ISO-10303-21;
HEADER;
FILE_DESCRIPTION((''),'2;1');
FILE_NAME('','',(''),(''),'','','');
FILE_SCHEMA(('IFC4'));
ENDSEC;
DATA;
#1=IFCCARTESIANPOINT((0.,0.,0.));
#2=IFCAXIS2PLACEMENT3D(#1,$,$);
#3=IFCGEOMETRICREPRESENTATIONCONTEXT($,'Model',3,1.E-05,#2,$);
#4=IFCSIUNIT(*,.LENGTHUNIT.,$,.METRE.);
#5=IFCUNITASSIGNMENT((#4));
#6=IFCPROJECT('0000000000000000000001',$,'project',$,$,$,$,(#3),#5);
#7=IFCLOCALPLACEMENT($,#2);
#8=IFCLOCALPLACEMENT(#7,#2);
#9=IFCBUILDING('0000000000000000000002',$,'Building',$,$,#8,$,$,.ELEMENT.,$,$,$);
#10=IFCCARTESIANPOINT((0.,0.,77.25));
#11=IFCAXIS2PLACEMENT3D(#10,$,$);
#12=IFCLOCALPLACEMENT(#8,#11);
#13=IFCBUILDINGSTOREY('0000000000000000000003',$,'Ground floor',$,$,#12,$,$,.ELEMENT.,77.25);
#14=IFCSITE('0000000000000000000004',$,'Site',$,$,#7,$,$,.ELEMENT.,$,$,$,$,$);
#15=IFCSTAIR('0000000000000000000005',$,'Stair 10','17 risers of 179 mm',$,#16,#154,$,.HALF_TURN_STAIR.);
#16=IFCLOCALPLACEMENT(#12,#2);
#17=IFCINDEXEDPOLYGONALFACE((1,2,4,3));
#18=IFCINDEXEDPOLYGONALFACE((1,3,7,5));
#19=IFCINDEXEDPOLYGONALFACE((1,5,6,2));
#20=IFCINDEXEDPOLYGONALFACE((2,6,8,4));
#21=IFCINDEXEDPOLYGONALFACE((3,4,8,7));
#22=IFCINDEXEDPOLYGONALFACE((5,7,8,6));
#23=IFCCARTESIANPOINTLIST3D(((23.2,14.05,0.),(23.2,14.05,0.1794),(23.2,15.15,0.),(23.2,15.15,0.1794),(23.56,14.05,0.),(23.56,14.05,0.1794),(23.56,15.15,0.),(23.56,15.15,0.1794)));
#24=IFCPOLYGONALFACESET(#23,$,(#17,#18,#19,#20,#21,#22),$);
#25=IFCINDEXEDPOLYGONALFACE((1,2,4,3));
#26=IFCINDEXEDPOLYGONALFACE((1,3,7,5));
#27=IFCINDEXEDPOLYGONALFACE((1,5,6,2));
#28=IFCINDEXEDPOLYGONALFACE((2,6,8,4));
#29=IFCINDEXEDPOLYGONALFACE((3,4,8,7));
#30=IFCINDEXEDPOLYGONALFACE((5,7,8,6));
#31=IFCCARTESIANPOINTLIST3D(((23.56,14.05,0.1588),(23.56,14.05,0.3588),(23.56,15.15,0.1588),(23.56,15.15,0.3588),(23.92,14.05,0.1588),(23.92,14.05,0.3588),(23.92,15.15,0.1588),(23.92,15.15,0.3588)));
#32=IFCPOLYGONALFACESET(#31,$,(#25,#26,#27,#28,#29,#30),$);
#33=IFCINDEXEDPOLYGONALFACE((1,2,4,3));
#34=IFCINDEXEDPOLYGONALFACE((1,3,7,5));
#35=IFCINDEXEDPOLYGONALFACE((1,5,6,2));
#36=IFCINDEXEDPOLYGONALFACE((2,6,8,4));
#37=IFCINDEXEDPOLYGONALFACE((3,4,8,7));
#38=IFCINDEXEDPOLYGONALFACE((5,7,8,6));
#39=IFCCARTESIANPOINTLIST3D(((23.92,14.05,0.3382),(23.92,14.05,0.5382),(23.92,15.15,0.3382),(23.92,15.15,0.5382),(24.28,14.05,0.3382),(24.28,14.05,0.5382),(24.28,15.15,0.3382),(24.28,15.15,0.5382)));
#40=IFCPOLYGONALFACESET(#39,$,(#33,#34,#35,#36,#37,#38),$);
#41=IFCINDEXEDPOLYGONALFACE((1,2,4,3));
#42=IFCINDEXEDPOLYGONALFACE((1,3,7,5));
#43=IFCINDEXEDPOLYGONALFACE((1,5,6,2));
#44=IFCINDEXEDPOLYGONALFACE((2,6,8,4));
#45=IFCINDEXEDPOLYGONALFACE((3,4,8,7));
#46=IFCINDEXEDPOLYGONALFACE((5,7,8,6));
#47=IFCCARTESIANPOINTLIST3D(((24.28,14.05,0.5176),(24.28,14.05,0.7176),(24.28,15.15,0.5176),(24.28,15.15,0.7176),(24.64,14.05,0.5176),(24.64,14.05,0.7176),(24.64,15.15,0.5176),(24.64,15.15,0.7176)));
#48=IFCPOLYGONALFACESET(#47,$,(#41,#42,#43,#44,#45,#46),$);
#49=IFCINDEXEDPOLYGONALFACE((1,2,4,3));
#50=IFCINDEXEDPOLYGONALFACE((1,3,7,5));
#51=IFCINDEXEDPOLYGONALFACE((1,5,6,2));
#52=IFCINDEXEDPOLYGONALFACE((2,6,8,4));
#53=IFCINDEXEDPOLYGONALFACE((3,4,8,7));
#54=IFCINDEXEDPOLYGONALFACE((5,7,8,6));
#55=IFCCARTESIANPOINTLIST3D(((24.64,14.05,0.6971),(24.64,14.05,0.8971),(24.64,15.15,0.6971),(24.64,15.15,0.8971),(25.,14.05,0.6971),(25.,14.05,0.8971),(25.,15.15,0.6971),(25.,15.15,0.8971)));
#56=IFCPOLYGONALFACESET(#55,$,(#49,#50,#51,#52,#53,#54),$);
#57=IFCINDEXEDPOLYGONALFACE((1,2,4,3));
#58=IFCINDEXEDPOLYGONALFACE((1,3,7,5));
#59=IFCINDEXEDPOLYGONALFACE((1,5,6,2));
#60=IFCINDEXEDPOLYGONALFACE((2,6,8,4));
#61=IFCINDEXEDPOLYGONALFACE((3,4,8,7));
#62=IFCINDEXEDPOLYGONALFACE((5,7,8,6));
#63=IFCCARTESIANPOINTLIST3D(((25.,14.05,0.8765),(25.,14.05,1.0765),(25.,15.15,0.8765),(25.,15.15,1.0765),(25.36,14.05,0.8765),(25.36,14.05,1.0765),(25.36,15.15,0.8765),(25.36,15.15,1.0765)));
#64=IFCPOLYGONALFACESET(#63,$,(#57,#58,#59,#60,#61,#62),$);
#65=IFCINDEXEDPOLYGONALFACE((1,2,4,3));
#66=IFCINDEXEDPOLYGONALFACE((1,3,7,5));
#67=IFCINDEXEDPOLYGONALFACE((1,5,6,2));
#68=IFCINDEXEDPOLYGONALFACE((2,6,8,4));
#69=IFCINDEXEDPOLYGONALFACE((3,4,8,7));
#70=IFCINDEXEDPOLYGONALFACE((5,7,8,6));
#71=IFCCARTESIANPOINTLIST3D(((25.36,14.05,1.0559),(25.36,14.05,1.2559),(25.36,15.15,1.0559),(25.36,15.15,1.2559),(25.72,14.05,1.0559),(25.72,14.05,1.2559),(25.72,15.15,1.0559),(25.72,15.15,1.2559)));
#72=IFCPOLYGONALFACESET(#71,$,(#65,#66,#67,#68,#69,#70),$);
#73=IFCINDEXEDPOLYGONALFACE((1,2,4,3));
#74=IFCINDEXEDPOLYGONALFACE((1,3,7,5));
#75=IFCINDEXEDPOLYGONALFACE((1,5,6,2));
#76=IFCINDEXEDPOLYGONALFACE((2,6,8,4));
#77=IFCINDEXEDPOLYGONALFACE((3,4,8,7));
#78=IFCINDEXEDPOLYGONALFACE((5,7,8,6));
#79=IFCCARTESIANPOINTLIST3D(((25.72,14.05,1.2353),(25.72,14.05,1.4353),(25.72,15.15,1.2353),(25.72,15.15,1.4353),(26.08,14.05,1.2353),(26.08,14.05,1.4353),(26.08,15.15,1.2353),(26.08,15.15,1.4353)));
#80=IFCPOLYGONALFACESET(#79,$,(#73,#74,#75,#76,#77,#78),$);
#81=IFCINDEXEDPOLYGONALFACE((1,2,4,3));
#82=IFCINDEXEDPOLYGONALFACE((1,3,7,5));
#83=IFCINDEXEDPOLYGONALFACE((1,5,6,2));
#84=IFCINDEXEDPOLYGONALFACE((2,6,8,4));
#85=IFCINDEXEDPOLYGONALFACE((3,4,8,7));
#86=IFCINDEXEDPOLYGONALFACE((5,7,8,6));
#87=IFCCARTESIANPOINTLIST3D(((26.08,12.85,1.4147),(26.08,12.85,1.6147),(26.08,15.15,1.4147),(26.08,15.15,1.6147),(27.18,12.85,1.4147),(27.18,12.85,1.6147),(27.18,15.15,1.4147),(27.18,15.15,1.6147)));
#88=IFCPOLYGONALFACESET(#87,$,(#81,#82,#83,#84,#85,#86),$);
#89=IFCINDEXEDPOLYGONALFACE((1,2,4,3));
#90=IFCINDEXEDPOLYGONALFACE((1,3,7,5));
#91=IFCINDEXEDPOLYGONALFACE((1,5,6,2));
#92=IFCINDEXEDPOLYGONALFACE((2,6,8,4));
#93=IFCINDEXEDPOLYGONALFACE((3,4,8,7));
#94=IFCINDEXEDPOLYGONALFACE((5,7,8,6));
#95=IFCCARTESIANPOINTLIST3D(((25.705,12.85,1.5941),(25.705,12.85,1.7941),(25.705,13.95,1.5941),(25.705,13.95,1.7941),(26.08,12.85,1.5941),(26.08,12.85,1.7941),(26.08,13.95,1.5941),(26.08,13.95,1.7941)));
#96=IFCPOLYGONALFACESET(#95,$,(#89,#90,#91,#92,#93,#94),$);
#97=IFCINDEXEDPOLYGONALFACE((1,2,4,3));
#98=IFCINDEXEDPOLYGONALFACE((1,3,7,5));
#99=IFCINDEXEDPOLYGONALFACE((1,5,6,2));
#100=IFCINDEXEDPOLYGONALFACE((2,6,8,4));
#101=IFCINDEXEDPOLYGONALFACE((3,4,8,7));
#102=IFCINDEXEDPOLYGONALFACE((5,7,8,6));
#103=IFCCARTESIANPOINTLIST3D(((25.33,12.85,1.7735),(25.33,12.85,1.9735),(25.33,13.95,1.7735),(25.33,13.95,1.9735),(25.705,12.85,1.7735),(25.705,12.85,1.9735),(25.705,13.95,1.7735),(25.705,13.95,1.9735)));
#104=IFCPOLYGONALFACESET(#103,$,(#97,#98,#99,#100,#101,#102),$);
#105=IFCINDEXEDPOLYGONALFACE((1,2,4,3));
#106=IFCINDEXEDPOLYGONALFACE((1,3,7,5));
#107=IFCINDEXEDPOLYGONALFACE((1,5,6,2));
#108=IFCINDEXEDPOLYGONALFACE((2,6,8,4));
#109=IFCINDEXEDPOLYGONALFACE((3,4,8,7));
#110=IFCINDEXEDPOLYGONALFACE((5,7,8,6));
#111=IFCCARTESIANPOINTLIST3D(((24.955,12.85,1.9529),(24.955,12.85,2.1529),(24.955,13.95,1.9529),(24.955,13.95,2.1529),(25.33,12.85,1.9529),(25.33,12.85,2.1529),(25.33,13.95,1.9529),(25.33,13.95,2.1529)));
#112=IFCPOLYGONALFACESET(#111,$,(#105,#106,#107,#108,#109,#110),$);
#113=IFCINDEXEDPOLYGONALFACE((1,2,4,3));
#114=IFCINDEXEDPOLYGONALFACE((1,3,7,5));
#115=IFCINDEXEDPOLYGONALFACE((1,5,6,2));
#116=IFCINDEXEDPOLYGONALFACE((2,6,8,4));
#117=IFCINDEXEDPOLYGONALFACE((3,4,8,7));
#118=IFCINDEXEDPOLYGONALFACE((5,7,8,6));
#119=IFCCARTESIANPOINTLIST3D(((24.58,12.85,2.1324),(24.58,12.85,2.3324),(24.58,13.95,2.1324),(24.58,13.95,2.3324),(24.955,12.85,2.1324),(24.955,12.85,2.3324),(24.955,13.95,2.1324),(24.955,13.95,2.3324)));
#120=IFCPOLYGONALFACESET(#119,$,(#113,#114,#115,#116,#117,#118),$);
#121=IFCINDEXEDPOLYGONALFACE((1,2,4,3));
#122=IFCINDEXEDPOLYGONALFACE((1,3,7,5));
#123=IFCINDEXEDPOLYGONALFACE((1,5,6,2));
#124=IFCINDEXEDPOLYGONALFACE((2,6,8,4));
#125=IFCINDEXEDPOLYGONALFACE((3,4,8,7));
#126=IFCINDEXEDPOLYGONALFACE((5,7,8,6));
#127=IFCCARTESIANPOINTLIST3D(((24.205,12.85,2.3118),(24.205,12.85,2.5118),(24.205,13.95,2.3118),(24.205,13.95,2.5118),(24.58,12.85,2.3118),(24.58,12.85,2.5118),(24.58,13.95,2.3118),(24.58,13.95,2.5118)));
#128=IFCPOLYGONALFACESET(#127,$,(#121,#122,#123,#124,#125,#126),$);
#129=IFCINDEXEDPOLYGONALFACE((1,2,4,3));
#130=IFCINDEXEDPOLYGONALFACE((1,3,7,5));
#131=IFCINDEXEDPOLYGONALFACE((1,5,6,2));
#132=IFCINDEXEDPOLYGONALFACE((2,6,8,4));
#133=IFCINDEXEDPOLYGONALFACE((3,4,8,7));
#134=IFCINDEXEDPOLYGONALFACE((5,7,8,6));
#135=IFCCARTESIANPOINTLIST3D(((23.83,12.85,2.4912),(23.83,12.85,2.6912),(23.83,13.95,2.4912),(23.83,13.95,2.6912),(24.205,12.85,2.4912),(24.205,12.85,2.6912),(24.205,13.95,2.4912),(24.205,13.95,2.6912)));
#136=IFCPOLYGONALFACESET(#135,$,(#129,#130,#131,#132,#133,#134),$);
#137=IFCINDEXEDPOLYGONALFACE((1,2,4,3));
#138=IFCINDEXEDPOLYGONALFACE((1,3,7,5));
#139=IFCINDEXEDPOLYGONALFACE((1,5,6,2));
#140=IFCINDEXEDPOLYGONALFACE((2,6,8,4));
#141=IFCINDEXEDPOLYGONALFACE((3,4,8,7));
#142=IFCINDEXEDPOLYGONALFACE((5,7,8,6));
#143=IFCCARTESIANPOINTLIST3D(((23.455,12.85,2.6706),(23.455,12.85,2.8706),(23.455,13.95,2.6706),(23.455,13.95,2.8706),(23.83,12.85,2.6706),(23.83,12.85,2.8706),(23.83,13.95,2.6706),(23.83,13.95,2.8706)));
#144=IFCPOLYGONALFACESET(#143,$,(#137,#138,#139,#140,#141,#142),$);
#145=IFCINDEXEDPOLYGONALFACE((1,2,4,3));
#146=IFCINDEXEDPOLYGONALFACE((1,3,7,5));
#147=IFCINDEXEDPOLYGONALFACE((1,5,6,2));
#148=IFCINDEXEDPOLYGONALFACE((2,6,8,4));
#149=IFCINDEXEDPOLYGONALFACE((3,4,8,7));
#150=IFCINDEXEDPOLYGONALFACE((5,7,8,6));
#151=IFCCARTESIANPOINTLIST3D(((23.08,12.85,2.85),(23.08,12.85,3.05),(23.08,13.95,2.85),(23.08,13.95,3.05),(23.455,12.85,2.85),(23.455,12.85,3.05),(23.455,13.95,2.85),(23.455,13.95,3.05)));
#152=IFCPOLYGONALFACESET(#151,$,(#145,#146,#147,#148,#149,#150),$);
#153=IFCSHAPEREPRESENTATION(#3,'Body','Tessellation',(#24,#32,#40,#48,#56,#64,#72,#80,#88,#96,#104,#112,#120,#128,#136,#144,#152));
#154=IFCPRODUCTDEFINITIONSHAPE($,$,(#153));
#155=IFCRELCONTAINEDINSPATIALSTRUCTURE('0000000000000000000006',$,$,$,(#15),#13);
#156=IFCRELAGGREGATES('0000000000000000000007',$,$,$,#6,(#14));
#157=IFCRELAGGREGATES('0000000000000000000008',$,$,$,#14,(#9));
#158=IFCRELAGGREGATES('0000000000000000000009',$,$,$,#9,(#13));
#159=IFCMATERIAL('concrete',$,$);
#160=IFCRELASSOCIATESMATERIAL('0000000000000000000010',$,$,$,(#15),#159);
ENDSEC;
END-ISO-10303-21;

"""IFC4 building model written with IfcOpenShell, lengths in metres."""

from ifc_helpers import new_model, si_unit, frame, origin, place, context, project, spatial, polyline, outline, extrude, material, element, save


model = new_model("IFC4")

# Units and contexts
model_context = context("Model", 3, precision=1e-05, world=origin())
ifc_project = project(units=[si_unit("LENGTHUNIT", "METRE")], contexts=[model_context])

# Site, building, storey
site_placement = place(None, origin())
site = spatial("IfcSite", under=ifc_project, at=site_placement, Name="Site", CompositionType="ELEMENT")
building_placement = place(site_placement, origin())
building = spatial("IfcBuilding", under=site, at=building_placement, Name="Building", CompositionType="ELEMENT")
storey_placement = place(building_placement, frame((0.0, 0.0, 77.25)))
storey = spatial("IfcBuildingStorey", under=building, at=storey_placement, Name="Ground floor", CompositionType="ELEMENT", Elevation=77.25)

# Shared definitions
ifc_material = material(Name="concrete")

# Stair
stair_1_placement = place(storey_placement, frame((23.2, 14.6, 0.0), z_axis=(0.0, 0.0, 1.0), x_axis=(1.0, 0.0, 0.0)))
element("IfcStair", 1, at=stair_1_placement, inside=storey, material=ifc_material, Name="Stair 10", Description="17 risers of 179 mm", PredefinedType="HALF_TURN_STAIR", context=model_context, shape_type="SweptSolid", body=[
    extrude(outline(polyline([(0.0, -0.55), (0.36, -0.55), (0.36, 0.55), (0.0, 0.55), (0.0, -0.55)])), origin(), (0.0, 0.0, 1.0), 0.1794),
    extrude(outline(polyline([(0.36, -0.55), (0.72, -0.55), (0.72, 0.55), (0.36, 0.55), (0.36, -0.55)])), frame((0.0, 0.0, 0.1588)), (0.0, 0.0, 1.0), 0.2),
    extrude(outline(polyline([(0.72, -0.55), (1.08, -0.55), (1.08, 0.55), (0.72, 0.55), (0.72, -0.55)])), frame((0.0, 0.0, 0.3382)), (0.0, 0.0, 1.0), 0.2),
    extrude(outline(polyline([(1.08, -0.55), (1.44, -0.55), (1.44, 0.55), (1.08, 0.55), (1.08, -0.55)])), frame((0.0, 0.0, 0.5176)), (0.0, 0.0, 1.0), 0.2),
    extrude(outline(polyline([(1.44, -0.55), (1.8, -0.55), (1.8, 0.55), (1.44, 0.55), (1.44, -0.55)])), frame((0.0, 0.0, 0.6971)), (0.0, 0.0, 1.0), 0.2),
    extrude(outline(polyline([(1.8, -0.55), (2.16, -0.55), (2.16, 0.55), (1.8, 0.55), (1.8, -0.55)])), frame((0.0, 0.0, 0.8765)), (0.0, 0.0, 1.0), 0.2),
    extrude(outline(polyline([(2.16, -0.55), (2.52, -0.55), (2.52, 0.55), (2.16, 0.55), (2.16, -0.55)])), frame((0.0, 0.0, 1.0559)), (0.0, 0.0, 1.0), 0.2),
    extrude(outline(polyline([(2.52, -0.55), (2.88, -0.55), (2.88, 0.55), (2.52, 0.55), (2.52, -0.55)])), frame((0.0, 0.0, 1.2353)), (0.0, 0.0, 1.0), 0.2),
    extrude(outline(polyline([(2.88, -1.75), (3.98, -1.75), (3.98, 0.55), (2.88, 0.55), (2.88, -1.75)])), frame((0.0, 0.0, 1.4147)), (0.0, 0.0, 1.0), 0.2),
    extrude(outline(polyline([(2.505, -1.75), (2.88, -1.75), (2.88, -0.65), (2.505, -0.65), (2.505, -1.75)])), frame((0.0, 0.0, 1.5941)), (0.0, 0.0, 1.0), 0.2),
    extrude(outline(polyline([(2.13, -1.75), (2.505, -1.75), (2.505, -0.65), (2.13, -0.65), (2.13, -1.75)])), frame((0.0, 0.0, 1.7735)), (0.0, 0.0, 1.0), 0.2),
    extrude(outline(polyline([(1.755, -1.75), (2.13, -1.75), (2.13, -0.65), (1.755, -0.65), (1.755, -1.75)])), frame((0.0, 0.0, 1.9529)), (0.0, 0.0, 1.0), 0.2),
    extrude(outline(polyline([(1.38, -1.75), (1.755, -1.75), (1.755, -0.65), (1.38, -0.65), (1.38, -1.75)])), frame((0.0, 0.0, 2.1324)), (0.0, 0.0, 1.0), 0.2),
    extrude(outline(polyline([(1.005, -1.75), (1.38, -1.75), (1.38, -0.65), (1.005, -0.65), (1.005, -1.75)])), frame((0.0, 0.0, 2.3118)), (0.0, 0.0, 1.0), 0.2),
    extrude(outline(polyline([(0.63, -1.75), (1.005, -1.75), (1.005, -0.65), (0.63, -0.65), (0.63, -1.75)])), frame((0.0, 0.0, 2.4912)), (0.0, 0.0, 1.0), 0.2),
    extrude(outline(polyline([(0.255, -1.75), (0.63, -1.75), (0.63, -0.65), (0.255, -0.65), (0.255, -1.75)])), frame((0.0, 0.0, 2.6706)), (0.0, 0.0, 1.0), 0.2),
    extrude(outline(polyline([(-0.12, -1.75), (0.255, -1.75), (0.255, -0.65), (-0.12, -0.65), (-0.12, -1.75)])), frame((0.0, 0.0, 2.85)), (0.0, 0.0, 1.0), 0.2),
])

save(model, "model.ifc")
